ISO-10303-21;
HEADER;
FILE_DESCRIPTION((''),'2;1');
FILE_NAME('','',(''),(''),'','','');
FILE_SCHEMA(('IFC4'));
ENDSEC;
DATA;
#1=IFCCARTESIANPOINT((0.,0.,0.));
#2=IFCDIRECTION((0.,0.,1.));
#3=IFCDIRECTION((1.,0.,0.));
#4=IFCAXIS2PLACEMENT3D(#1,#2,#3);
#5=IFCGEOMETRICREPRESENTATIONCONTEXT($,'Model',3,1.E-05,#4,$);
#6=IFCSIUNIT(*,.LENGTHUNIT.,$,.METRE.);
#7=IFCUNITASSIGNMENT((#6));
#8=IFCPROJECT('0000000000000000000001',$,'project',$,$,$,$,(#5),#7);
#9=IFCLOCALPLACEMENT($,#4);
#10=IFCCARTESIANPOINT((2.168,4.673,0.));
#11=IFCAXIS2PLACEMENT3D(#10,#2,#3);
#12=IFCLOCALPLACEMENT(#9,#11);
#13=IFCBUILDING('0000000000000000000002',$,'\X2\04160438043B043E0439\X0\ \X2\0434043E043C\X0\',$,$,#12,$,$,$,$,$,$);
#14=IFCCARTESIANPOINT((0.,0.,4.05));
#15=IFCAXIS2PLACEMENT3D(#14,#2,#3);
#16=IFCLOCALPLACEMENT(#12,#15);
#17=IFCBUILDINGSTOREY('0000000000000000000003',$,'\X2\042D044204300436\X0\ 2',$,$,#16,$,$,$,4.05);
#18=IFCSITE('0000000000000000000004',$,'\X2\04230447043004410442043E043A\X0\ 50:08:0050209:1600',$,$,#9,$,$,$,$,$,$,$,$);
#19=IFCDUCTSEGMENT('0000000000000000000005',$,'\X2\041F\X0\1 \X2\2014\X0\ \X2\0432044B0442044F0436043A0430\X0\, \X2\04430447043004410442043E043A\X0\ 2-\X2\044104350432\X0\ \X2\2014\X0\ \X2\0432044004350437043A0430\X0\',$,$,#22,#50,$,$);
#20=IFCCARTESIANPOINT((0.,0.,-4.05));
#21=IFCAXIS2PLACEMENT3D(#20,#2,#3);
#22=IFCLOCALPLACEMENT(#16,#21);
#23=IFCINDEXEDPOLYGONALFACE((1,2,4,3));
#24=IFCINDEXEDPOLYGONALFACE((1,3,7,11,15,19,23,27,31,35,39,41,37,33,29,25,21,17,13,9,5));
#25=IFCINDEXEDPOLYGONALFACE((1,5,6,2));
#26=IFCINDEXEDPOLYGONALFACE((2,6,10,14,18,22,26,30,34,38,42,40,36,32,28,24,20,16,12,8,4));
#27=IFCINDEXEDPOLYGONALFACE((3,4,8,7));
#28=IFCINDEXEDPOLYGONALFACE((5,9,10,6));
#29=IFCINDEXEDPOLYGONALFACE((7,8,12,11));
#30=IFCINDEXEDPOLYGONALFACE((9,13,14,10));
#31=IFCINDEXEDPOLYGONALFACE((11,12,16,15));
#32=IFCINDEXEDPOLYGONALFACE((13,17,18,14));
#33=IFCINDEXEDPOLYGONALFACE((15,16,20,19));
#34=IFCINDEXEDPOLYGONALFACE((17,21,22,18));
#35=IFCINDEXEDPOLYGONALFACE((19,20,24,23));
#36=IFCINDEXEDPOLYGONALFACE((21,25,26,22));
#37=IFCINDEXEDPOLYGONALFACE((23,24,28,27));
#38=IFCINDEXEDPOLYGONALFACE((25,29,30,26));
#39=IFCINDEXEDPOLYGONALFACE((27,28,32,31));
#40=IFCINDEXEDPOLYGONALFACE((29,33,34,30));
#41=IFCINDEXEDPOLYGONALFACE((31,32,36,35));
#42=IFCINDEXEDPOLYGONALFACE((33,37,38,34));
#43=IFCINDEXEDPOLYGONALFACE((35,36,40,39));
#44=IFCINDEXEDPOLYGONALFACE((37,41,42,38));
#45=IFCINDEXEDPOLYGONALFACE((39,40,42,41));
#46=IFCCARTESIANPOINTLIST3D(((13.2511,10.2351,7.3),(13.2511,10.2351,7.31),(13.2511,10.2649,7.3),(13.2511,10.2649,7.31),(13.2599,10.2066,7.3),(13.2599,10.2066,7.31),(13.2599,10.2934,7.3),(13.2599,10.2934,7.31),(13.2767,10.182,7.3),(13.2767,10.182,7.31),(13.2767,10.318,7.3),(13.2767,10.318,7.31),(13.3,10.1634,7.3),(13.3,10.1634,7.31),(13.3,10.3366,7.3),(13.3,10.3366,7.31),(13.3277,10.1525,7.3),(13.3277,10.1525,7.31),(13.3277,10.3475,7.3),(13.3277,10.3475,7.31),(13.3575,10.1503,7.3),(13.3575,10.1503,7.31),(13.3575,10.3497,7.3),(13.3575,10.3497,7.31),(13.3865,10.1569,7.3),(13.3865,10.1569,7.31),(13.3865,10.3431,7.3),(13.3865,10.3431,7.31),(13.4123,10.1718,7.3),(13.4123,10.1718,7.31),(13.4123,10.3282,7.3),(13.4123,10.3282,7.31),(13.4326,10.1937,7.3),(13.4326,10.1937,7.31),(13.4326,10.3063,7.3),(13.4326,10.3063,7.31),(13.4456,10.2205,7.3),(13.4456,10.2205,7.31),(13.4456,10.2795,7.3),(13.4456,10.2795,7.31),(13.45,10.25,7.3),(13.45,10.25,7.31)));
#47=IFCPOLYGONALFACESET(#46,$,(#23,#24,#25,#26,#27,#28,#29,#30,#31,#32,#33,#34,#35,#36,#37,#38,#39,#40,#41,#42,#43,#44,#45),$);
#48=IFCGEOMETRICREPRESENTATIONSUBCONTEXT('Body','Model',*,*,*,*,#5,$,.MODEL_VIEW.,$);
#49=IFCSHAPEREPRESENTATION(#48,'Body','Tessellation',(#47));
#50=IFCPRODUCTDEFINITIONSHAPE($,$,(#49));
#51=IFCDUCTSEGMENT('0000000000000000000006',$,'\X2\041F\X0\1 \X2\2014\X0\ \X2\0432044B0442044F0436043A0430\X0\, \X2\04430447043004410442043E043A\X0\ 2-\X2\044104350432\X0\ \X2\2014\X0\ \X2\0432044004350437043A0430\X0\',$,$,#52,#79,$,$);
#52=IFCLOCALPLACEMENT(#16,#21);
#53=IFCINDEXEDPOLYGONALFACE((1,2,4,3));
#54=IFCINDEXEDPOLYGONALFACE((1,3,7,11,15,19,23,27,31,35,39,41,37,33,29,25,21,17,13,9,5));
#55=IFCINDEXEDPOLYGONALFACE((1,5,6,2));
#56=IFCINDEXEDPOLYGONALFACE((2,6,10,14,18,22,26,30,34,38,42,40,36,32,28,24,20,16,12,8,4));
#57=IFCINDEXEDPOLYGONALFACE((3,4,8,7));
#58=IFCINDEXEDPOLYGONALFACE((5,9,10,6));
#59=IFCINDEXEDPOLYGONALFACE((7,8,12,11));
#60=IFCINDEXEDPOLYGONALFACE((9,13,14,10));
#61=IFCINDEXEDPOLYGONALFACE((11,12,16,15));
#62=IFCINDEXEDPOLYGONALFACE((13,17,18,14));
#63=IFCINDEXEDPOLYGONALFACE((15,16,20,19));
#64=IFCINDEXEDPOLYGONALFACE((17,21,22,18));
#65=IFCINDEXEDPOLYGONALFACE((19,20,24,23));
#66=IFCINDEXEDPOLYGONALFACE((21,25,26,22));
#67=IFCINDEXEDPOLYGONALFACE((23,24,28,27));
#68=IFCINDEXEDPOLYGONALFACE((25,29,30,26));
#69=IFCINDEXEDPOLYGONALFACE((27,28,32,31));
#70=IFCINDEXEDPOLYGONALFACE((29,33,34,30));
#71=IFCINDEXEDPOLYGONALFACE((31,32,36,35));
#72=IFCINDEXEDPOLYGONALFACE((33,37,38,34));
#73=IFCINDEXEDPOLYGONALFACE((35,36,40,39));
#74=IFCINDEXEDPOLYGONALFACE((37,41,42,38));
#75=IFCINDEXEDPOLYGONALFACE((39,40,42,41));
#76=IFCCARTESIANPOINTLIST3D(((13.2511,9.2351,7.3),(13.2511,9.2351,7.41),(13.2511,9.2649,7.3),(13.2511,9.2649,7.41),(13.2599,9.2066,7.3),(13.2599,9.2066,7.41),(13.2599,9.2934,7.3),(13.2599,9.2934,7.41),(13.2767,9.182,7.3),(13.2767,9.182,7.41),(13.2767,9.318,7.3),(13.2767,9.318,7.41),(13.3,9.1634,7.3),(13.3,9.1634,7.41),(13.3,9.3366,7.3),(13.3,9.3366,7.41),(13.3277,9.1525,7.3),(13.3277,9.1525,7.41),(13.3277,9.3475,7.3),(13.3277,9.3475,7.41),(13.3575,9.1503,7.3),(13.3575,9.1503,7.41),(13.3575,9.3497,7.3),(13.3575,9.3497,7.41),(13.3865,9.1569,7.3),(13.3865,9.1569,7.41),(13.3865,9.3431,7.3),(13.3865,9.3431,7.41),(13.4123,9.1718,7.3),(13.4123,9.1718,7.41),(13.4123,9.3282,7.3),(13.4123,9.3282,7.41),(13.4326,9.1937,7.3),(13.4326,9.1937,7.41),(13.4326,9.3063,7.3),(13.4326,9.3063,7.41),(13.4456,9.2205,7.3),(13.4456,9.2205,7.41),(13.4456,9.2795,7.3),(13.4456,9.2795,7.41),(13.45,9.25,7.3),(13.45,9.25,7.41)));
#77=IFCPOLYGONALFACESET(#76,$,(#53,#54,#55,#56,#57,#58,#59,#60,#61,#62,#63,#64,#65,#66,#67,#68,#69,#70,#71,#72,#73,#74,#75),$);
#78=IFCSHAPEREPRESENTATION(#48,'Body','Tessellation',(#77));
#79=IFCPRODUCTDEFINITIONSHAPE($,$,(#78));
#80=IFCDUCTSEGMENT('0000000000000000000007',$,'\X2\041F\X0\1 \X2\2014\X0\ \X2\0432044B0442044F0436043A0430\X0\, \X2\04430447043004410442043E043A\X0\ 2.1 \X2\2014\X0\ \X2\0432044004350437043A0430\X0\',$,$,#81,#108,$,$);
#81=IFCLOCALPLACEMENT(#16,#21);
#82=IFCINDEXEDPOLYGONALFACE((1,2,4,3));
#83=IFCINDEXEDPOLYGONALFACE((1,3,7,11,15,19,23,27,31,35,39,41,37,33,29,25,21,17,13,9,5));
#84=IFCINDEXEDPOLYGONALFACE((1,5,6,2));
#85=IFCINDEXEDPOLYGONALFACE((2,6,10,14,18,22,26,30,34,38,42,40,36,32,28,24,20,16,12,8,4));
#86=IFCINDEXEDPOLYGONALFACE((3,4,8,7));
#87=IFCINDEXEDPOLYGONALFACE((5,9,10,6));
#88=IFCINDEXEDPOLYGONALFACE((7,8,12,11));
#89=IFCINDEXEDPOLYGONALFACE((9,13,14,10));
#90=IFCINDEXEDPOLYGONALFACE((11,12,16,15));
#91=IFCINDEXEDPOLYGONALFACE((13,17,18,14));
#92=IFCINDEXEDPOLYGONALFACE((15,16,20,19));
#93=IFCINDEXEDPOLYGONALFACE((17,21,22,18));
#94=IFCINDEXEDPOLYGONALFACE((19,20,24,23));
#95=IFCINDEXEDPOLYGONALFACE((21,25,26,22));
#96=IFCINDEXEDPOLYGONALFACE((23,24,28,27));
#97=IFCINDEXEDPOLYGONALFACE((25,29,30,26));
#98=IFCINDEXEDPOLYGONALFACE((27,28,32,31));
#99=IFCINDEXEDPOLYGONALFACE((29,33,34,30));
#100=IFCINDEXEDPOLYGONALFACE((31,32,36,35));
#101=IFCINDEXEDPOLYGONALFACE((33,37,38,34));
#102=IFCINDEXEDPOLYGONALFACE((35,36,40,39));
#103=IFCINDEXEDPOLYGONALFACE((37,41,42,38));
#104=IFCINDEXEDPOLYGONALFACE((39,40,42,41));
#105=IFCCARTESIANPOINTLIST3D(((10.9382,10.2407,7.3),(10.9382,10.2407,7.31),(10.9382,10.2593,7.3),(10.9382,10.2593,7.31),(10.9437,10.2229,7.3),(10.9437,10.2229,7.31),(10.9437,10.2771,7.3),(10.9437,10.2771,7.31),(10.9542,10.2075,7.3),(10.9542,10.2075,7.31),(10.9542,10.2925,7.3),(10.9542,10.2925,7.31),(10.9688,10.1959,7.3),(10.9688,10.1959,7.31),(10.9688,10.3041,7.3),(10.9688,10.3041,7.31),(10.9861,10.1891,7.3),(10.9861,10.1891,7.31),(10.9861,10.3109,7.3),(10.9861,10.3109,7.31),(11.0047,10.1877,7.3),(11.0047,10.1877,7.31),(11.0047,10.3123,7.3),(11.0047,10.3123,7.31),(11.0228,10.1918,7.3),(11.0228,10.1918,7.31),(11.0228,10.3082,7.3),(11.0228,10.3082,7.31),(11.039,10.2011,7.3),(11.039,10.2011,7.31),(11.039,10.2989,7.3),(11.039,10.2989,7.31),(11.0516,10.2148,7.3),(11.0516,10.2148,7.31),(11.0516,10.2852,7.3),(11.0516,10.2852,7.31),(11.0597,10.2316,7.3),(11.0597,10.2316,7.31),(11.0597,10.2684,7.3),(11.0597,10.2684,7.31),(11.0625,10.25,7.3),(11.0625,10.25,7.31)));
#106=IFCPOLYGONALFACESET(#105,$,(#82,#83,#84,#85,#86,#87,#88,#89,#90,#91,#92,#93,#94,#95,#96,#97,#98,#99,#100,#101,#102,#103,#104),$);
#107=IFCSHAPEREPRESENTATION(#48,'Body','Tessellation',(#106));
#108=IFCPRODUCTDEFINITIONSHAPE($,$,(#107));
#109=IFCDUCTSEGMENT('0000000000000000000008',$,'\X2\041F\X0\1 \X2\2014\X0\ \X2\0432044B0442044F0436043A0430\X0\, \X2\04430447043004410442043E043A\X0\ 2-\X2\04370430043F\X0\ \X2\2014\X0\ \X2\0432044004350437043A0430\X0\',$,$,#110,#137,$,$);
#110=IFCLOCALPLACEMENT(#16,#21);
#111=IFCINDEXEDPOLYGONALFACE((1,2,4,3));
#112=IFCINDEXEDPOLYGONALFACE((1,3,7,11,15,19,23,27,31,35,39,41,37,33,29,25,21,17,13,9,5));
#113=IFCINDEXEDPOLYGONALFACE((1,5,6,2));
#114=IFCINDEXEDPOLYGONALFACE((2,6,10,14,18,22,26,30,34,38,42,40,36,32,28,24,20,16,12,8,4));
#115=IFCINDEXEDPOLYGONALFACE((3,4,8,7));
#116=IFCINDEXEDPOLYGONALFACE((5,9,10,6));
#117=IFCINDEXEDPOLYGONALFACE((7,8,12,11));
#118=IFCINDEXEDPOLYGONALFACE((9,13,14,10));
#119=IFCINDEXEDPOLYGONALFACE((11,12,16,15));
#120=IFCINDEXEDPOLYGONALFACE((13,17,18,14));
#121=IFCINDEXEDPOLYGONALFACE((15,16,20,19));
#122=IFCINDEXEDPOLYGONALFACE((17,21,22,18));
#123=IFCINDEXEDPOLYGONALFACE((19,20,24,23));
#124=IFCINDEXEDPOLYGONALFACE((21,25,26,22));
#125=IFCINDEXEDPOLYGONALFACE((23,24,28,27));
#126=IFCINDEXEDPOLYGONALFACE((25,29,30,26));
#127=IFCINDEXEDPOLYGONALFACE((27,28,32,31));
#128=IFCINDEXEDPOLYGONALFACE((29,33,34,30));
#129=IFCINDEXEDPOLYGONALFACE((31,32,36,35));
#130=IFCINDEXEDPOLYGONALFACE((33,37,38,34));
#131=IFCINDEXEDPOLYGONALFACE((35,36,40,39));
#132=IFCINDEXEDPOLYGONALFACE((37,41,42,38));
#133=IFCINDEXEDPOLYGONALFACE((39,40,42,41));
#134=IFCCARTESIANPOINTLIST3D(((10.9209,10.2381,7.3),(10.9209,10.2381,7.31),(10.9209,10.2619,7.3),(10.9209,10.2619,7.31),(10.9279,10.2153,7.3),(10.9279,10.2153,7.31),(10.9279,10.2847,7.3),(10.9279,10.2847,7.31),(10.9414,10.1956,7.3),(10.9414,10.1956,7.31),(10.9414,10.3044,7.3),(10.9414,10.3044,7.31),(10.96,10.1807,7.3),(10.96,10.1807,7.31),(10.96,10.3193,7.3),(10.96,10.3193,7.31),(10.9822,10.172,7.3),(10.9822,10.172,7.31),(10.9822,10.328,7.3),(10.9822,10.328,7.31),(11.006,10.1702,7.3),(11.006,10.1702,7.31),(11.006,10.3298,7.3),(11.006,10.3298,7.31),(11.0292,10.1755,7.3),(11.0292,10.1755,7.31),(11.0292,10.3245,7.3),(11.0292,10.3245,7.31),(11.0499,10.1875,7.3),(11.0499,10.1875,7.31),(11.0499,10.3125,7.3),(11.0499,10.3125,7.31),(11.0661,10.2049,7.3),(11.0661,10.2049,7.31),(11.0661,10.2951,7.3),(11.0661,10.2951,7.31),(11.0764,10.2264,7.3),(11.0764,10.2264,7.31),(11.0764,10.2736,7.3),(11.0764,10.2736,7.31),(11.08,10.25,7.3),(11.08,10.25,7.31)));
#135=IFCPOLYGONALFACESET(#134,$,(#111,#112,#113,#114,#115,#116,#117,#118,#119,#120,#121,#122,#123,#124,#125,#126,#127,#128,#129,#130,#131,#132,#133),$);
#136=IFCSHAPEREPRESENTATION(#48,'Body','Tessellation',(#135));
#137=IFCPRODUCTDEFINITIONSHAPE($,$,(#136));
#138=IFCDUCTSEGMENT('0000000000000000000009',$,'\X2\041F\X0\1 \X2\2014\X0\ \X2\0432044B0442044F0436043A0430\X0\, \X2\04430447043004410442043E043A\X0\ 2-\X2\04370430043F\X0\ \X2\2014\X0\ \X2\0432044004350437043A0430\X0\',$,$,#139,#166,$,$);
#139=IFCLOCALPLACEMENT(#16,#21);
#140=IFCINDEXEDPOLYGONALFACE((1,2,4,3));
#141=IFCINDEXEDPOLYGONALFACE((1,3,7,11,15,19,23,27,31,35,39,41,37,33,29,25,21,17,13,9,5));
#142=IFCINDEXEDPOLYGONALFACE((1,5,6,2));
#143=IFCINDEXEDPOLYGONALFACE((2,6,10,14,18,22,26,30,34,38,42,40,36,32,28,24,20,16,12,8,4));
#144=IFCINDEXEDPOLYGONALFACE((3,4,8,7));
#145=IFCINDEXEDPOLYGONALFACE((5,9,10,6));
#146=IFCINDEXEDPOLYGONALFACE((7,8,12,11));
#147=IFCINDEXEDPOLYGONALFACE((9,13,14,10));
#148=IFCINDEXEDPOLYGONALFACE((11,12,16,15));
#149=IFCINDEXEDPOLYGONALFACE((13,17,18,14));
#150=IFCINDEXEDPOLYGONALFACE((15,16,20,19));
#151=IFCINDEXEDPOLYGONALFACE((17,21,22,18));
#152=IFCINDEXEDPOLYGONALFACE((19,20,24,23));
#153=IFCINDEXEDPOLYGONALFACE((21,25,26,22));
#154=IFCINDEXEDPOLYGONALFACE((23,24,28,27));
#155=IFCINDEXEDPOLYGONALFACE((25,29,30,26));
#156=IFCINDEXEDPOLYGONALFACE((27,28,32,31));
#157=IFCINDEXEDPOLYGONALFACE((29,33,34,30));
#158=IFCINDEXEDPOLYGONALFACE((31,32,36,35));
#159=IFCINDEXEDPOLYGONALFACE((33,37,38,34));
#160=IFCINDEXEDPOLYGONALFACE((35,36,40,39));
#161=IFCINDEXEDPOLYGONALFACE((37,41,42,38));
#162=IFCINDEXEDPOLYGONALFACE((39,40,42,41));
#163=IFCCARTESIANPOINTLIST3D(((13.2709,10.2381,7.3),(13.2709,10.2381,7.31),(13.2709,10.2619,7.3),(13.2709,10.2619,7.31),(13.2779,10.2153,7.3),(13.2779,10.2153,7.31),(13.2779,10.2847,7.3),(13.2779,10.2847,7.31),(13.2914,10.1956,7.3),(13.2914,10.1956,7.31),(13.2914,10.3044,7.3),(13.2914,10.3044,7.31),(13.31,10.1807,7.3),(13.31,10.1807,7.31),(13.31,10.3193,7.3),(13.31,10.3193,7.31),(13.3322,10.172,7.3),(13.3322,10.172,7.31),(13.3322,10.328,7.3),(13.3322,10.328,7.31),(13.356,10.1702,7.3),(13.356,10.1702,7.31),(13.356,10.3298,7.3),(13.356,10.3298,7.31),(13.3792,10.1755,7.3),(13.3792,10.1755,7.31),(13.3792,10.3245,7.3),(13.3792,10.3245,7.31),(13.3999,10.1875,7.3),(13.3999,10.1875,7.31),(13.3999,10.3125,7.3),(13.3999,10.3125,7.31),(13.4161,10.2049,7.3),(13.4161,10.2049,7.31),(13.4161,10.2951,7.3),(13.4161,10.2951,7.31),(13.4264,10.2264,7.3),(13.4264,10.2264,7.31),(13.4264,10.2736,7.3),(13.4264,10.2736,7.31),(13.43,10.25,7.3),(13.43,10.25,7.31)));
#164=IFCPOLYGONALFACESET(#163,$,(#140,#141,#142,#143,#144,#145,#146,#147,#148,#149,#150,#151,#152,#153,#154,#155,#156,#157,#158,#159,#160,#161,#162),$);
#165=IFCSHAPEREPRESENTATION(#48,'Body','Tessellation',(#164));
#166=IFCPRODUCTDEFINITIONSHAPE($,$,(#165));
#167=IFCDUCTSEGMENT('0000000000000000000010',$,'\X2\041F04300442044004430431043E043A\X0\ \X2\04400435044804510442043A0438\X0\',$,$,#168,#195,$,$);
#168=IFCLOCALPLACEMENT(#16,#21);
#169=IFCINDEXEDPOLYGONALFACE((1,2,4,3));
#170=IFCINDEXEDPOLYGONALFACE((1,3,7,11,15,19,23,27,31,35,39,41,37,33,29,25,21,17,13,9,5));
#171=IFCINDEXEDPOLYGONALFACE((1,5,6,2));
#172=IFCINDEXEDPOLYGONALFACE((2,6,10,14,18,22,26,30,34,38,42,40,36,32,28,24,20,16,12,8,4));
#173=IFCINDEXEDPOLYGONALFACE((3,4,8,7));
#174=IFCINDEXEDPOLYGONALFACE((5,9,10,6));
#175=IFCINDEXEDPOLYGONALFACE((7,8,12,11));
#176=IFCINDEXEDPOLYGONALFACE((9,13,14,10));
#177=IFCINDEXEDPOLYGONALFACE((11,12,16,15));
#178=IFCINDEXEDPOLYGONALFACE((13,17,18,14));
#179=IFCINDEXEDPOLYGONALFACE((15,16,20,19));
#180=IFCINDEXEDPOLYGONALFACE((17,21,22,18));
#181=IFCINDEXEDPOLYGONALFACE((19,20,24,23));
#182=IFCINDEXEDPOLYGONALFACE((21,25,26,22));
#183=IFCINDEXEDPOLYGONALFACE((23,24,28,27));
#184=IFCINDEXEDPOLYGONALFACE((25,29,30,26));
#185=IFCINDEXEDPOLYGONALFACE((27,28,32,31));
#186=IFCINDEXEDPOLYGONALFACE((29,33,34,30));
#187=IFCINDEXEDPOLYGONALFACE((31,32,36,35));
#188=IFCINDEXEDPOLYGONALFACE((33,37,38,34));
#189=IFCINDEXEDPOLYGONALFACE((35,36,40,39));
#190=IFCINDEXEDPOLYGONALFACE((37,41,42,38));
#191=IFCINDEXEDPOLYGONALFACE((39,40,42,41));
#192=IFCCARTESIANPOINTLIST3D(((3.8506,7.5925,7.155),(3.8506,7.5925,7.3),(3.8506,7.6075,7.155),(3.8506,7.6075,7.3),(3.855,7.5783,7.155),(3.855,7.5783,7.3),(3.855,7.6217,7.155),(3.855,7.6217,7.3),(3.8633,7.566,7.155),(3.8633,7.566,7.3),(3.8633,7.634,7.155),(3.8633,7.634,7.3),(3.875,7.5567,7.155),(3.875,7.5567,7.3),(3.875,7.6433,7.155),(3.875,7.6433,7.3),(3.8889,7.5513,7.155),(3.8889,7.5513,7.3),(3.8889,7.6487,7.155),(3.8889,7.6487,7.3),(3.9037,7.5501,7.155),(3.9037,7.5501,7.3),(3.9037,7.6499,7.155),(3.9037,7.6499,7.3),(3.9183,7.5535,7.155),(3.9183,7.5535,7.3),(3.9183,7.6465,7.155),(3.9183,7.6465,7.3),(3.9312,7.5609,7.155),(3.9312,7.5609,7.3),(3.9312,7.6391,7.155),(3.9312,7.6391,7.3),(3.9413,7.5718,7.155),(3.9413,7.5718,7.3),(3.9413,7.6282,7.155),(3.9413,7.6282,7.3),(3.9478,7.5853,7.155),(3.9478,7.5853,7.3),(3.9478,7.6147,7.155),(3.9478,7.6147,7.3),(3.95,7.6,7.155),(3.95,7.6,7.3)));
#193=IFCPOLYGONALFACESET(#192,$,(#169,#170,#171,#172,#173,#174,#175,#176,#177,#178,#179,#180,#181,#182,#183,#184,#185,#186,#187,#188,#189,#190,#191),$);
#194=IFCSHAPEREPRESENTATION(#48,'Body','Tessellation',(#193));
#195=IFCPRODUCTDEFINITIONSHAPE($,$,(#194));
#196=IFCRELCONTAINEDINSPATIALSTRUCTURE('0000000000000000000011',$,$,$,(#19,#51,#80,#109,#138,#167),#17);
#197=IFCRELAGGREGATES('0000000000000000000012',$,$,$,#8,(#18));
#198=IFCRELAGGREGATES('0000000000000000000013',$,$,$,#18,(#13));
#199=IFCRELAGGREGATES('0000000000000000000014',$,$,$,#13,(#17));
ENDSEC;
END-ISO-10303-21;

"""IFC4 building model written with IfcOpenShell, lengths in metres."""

from ifc_helpers import new_model, si_unit, frame, origin_with_axes, origin_2d, place, context, subcontext, project, spatial, circle, extrude, element, save


model = new_model("IFC4")

# Units and contexts
model_context = context("Model", 3, precision=1e-05, world=origin_with_axes())
body_context = subcontext(model_context, "Body", "Model", "MODEL_VIEW")
ifc_project = project(units=[si_unit("LENGTHUNIT", "METRE")], contexts=[model_context])

# Site, building, storey
site_placement = place(None, origin_with_axes())
site = spatial("IfcSite", under=ifc_project, at=site_placement, Name="Участок 50:08:0050209:1600")
building_placement = place(site_placement, frame((2.168, 4.673, 0.0), z_axis=(0.0, 0.0, 1.0), x_axis=(1.0, 0.0, 0.0)))
building = spatial("IfcBuilding", under=site, at=building_placement, Name="Жилой дом")
storey_placement = place(building_placement, frame((0.0, 0.0, 4.05), z_axis=(0.0, 0.0, 1.0), x_axis=(1.0, 0.0, 0.0)))
storey = spatial("IfcBuildingStorey", under=building, at=storey_placement, Name="Этаж 2", Elevation=4.05)

# Duct segments
duct_segment_1_placement = place(storey_placement, frame((0.0, 0.0, -4.05), z_axis=(0.0, 0.0, 1.0), x_axis=(1.0, 0.0, 0.0)))
element("IfcDuctSegment", 1, at=duct_segment_1_placement, inside=storey, Name="П1 — вытяжка, участок 2-сев — врезка", context=body_context, shape_type="SweptSolid", body=[
    extrude(circle(Radius=0.1, at=origin_2d()), frame((13.35, 10.25, 7.3), z_axis=(0.0, 0.0, 1.0), x_axis=(1.0, 0.0, 0.0)), (0.0, 0.0, 1.0), 0.01),
])
duct_segment_2_placement = place(storey_placement, frame((0.0, 0.0, -4.05), z_axis=(0.0, 0.0, 1.0), x_axis=(1.0, 0.0, 0.0)))
element("IfcDuctSegment", 2, at=duct_segment_2_placement, inside=storey, Name="П1 — вытяжка, участок 2-сев — врезка", context=body_context, shape_type="SweptSolid", body=[
    extrude(circle(Radius=0.1, at=origin_2d()), frame((13.35, 9.25, 7.3), z_axis=(0.0, 0.0, 1.0), x_axis=(1.0, 0.0, 0.0)), (0.0, 0.0, 1.0), 0.11),
])
duct_segment_3_placement = place(storey_placement, frame((0.0, 0.0, -4.05), z_axis=(0.0, 0.0, 1.0), x_axis=(1.0, 0.0, 0.0)))
element("IfcDuctSegment", 3, at=duct_segment_3_placement, inside=storey, Name="П1 — вытяжка, участок 2.1 — врезка", context=body_context, shape_type="SweptSolid", body=[
    extrude(circle(Radius=0.0625, at=origin_2d()), frame((11.0, 10.25, 7.3), z_axis=(0.0, 0.0, 1.0), x_axis=(1.0, 0.0, 0.0)), (0.0, 0.0, 1.0), 0.01),
])
duct_segment_4_placement = place(storey_placement, frame((0.0, 0.0, -4.05), z_axis=(0.0, 0.0, 1.0), x_axis=(1.0, 0.0, 0.0)))
element("IfcDuctSegment", 4, at=duct_segment_4_placement, inside=storey, Name="П1 — вытяжка, участок 2-зап — врезка", context=body_context, shape_type="SweptSolid", body=[
    extrude(circle(Radius=0.08, at=origin_2d()), frame((11.0, 10.25, 7.31), z_axis=(0.0, 0.0, -1.0), x_axis=(1.0, 0.0, 0.0)), (0.0, 0.0, 1.0), 0.01),
])
duct_segment_5_placement = place(storey_placement, frame((0.0, 0.0, -4.05), z_axis=(0.0, 0.0, 1.0), x_axis=(1.0, 0.0, 0.0)))
element("IfcDuctSegment", 5, at=duct_segment_5_placement, inside=storey, Name="П1 — вытяжка, участок 2-зап — врезка", context=body_context, shape_type="SweptSolid", body=[
    extrude(circle(Radius=0.08, at=origin_2d()), frame((13.35, 10.25, 7.31), z_axis=(0.0, 0.0, -1.0), x_axis=(1.0, 0.0, 0.0)), (0.0, 0.0, 1.0), 0.01),
])
duct_segment_6_placement = place(storey_placement, frame((0.0, 0.0, -4.05), z_axis=(0.0, 0.0, 1.0), x_axis=(1.0, 0.0, 0.0)))
element("IfcDuctSegment", 6, at=duct_segment_6_placement, inside=storey, Name="Патрубок решётки", context=body_context, shape_type="SweptSolid", body=[
    extrude(circle(Radius=0.05, at=origin_2d()), frame((3.9, 7.6, 7.3), z_axis=(0.0, 0.0, -1.0), x_axis=(1.0, 0.0, 0.0)), (0.0, 0.0, 1.0), 0.145),
])

save(model, "model.ifc")
